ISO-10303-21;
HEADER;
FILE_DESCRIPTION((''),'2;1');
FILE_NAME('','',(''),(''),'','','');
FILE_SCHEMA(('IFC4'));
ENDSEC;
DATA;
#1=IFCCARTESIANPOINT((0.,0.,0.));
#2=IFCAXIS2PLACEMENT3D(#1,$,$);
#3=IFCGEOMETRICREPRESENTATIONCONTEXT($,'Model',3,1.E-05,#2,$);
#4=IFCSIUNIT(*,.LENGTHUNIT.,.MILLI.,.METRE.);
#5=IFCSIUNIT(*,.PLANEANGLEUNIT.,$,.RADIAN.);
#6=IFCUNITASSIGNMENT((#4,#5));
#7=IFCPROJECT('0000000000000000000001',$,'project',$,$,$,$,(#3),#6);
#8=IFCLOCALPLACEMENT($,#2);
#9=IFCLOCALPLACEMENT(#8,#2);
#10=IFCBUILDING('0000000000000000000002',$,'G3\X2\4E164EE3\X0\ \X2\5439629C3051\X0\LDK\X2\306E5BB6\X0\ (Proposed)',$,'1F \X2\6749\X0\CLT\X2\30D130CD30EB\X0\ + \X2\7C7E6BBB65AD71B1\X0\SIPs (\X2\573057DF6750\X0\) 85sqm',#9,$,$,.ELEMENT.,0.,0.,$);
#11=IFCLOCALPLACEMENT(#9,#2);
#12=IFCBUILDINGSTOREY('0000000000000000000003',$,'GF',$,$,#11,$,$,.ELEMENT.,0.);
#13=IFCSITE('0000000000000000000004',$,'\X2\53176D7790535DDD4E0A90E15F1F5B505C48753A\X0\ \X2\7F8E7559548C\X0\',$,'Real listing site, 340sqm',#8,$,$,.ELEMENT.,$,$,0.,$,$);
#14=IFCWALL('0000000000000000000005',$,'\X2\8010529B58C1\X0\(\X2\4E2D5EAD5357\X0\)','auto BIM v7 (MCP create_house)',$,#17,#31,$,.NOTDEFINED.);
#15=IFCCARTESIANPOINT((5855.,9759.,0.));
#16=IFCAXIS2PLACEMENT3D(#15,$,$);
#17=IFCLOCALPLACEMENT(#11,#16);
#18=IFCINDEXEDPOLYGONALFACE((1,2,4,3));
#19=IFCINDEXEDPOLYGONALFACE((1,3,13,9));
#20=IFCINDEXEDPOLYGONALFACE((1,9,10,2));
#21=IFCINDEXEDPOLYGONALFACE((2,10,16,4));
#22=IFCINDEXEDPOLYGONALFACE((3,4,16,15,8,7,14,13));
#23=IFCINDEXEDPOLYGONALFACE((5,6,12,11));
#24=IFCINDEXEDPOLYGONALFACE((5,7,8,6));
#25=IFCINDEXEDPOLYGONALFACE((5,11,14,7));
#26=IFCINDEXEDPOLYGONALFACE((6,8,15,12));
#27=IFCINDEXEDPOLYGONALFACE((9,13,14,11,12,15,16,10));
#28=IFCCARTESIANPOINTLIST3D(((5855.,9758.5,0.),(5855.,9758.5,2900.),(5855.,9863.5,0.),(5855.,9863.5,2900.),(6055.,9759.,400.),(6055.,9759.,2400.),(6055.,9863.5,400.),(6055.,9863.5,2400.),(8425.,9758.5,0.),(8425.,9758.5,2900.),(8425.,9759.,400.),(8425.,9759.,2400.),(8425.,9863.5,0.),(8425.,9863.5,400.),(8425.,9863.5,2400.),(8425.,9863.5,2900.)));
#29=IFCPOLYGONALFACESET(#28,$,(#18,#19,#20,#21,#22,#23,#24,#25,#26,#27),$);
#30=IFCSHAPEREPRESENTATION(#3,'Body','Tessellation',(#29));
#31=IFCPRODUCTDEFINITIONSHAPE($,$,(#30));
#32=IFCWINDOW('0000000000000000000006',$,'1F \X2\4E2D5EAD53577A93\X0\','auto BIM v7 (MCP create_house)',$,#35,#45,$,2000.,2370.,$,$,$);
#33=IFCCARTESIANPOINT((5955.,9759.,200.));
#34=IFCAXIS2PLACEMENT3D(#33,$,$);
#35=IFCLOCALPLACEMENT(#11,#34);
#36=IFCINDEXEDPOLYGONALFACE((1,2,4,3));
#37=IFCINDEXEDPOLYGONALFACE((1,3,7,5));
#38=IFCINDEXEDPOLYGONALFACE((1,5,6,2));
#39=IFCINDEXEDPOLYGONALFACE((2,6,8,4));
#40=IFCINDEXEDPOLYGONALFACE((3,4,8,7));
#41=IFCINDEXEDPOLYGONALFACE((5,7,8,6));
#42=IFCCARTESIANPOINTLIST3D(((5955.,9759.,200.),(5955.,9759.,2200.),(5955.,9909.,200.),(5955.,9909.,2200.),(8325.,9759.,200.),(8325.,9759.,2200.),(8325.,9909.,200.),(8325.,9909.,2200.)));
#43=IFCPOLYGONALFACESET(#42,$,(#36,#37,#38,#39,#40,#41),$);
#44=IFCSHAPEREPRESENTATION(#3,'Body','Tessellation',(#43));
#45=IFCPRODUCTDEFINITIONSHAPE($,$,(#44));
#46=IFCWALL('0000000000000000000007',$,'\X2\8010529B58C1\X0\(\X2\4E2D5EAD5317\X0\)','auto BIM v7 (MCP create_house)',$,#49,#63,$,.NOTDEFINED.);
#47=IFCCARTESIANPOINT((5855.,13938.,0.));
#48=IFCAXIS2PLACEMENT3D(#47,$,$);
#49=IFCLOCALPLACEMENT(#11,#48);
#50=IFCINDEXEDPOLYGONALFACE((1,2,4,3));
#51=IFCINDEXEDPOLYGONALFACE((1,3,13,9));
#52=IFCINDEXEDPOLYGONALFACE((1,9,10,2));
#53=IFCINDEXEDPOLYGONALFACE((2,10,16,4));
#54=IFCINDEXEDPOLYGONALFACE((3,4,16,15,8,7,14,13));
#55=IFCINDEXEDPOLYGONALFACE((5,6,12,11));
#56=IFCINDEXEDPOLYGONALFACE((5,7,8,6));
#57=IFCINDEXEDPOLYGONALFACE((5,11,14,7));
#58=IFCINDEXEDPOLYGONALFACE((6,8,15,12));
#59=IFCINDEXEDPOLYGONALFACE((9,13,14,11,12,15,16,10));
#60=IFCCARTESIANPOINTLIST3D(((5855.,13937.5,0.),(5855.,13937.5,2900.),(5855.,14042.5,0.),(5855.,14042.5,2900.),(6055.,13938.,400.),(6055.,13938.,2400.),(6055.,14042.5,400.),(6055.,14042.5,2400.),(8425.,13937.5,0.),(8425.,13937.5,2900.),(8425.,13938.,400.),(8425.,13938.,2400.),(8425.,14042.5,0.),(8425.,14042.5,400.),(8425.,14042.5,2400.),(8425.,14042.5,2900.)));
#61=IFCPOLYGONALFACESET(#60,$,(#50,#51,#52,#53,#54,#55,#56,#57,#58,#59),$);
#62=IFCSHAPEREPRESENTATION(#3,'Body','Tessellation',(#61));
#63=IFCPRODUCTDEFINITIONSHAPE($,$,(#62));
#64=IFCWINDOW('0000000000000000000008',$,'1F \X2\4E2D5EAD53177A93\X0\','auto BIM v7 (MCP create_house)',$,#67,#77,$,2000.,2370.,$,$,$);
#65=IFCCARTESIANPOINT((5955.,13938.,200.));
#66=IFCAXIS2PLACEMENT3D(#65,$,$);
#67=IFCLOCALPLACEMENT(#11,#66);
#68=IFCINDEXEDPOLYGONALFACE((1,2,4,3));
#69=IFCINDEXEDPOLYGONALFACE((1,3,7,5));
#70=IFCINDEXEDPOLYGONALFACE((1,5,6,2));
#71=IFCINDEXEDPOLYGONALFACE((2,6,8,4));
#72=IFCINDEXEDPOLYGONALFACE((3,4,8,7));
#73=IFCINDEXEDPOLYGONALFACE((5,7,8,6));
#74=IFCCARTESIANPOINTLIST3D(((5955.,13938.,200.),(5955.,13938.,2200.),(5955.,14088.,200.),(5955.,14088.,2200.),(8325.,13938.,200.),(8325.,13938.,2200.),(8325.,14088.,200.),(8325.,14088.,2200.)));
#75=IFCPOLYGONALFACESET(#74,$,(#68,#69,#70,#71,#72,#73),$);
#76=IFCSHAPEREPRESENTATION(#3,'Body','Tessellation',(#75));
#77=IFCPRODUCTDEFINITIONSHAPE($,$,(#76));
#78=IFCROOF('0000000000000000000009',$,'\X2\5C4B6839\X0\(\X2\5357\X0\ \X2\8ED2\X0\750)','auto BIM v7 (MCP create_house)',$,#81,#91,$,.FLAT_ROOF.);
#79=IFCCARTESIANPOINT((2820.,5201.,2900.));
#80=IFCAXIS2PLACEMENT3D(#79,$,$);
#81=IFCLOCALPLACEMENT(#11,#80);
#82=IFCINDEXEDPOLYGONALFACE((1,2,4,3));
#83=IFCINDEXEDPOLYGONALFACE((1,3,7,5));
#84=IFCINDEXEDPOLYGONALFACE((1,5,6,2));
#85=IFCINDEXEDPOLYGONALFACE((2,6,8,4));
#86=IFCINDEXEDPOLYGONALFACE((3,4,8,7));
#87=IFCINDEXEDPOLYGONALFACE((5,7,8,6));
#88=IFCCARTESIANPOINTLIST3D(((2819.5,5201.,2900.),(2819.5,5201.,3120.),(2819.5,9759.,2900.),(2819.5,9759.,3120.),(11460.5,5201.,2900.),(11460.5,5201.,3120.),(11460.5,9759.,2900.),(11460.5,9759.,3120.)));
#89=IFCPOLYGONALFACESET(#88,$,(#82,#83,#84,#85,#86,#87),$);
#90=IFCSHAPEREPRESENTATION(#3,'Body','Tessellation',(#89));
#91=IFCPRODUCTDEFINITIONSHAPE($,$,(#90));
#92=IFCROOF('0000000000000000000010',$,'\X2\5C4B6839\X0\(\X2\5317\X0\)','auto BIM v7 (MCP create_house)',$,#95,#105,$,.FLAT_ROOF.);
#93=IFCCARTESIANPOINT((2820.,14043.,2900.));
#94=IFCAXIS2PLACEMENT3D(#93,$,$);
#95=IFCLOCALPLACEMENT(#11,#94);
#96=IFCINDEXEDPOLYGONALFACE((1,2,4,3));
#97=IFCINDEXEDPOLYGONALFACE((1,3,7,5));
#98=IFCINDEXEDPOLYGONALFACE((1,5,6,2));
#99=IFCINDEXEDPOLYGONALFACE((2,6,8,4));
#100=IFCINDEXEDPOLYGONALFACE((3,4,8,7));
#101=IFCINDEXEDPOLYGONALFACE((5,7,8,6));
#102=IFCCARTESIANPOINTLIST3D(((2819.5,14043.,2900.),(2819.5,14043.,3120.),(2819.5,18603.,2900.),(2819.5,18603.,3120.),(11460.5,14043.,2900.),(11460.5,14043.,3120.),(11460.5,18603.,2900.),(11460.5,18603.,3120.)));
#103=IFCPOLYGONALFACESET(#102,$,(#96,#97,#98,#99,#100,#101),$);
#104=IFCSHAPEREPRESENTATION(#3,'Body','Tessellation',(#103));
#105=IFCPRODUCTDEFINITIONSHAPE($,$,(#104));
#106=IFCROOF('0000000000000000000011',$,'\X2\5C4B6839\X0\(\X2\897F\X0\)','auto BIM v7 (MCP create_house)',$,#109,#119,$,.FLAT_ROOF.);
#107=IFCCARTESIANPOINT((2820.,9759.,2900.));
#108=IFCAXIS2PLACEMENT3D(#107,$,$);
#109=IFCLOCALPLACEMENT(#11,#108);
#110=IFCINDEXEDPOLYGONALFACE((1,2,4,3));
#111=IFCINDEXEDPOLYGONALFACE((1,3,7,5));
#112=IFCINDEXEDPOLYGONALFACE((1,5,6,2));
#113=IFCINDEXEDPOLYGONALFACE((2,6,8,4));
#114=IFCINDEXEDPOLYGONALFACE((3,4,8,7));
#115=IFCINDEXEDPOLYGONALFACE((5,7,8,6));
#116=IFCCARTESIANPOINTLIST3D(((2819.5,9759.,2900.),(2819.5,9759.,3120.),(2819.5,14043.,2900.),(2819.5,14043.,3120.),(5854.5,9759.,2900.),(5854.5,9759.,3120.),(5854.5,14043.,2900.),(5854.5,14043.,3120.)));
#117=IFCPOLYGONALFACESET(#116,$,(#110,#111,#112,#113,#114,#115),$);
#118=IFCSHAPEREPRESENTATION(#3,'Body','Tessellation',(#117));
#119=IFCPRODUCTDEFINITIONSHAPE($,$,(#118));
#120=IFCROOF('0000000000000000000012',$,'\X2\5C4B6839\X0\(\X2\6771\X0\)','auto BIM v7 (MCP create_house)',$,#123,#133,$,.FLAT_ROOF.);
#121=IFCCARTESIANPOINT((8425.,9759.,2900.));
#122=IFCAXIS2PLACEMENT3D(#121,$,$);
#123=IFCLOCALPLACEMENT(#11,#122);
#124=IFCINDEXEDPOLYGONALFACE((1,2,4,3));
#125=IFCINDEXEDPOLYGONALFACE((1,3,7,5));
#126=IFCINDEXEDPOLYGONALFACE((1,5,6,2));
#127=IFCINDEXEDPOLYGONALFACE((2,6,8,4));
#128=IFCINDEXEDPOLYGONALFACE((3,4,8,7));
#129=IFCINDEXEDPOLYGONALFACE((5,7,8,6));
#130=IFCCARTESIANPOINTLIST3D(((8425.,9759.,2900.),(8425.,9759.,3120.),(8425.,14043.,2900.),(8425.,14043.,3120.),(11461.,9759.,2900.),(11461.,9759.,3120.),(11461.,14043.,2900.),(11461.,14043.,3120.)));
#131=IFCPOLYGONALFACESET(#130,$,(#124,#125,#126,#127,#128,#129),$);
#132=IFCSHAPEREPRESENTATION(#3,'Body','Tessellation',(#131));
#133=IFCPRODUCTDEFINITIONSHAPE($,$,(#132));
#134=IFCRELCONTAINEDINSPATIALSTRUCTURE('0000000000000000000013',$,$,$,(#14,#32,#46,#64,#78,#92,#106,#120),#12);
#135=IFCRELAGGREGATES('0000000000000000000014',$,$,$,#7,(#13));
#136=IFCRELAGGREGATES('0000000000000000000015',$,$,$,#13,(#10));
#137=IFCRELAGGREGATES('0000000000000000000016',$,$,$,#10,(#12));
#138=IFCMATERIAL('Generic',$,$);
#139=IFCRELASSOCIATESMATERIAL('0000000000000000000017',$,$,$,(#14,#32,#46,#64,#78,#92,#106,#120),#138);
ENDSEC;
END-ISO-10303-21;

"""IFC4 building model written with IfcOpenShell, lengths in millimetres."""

from ifc_helpers import new_model, si_unit, frame, frame_2d, origin, place, context, project, spatial, rectangle, extrude, material, element, fill, save


model = new_model("IFC4")

# Units and contexts
model_context = context("Model", 3, precision=1e-05, world=origin())
ifc_project = project(units=[si_unit("LENGTHUNIT", "METRE", prefix="MILLI"), si_unit("PLANEANGLEUNIT", "RADIAN")], contexts=[model_context])

# Site, building, storey
site_placement = place(None, origin())
site = spatial("IfcSite", under=ifc_project, at=site_placement, Name="北海道川上郡弟子屈町 美留和", ObjectType="Real listing site, 340sqm", CompositionType="ELEMENT", RefElevation=0.0)
building_placement = place(site_placement, origin())
building = spatial("IfcBuilding", under=site, at=building_placement, Name="G3世代 吹抜けLDKの家 (Proposed)", ObjectType="1F 杉CLTパネル + 籾殻断熱SIPs (地域材) 85sqm", CompositionType="ELEMENT", ElevationOfRefHeight=0.0, ElevationOfTerrain=0.0)
storey_placement = place(building_placement, origin())
storey = spatial("IfcBuildingStorey", under=building, at=storey_placement, Name="GF", CompositionType="ELEMENT", Elevation=0.0)

# Shared definitions
ifc_material = material(Name="Generic")

# Walls, openings, windows
wall_1_placement = place(storey_placement, frame((5855.0, 9759.0, 0.0)))
wall_1 = element("IfcWall", 1, at=wall_1_placement, inside=storey, material=ifc_material, Name="耐力壁(中庭南)", Description="auto BIM v7 (MCP create_house)", PredefinedType="NOTDEFINED", context=model_context, shape_type="SweptSolid", body=[
    extrude(rectangle(XDim=2570.0, YDim=105.0, at=frame_2d((1285.0, 52.0))), frame((5855.0, 9759.0, 0.0)), (0.0, 0.0, 1.0), 2900.0),
])
opening_1_placement = place(storey_placement, frame((5955.0, 9759.0, 200.0)))
opening_1 = element("IfcOpeningElement", 2, at=opening_1_placement, cuts=wall_1, PredefinedType="NOTDEFINED", context=model_context, shape_type="SweptSolid", body=[
    extrude(rectangle(XDim=2370.0, YDim=150.0, at=frame_2d((1185.0, 75.0))), frame((5955.0, 9759.0, 200.0)), (0.0, 0.0, 1.0), 2000.0),
])
window_1_placement = place(storey_placement, frame((5955.0, 9759.0, 200.0)))
window_1 = element("IfcWindow", 3, at=window_1_placement, inside=storey, material=ifc_material, Name="1F 中庭南窓", Description="auto BIM v7 (MCP create_house)", OverallHeight=2000.0, OverallWidth=2370.0, context=model_context, shape_type="SweptSolid", body=[
    extrude(rectangle(XDim=2370.0, YDim=150.0, at=frame_2d((1185.0, 75.0))), frame((5955.0, 9759.0, 200.0)), (0.0, 0.0, 1.0), 2000.0),
])
fill(opening_1, window_1)
wall_2_placement = place(storey_placement, frame((5855.0, 13938.0, 0.0)))
wall_2 = element("IfcWall", 4, at=wall_2_placement, inside=storey, material=ifc_material, Name="耐力壁(中庭北)", Description="auto BIM v7 (MCP create_house)", PredefinedType="NOTDEFINED", context=model_context, shape_type="SweptSolid", body=[
    extrude(rectangle(XDim=2570.0, YDim=105.0, at=frame_2d((1285.0, 52.0))), frame((5855.0, 13938.0, 0.0)), (0.0, 0.0, 1.0), 2900.0),
])
opening_2_placement = place(storey_placement, frame((5955.0, 13938.0, 200.0)))
opening_2 = element("IfcOpeningElement", 5, at=opening_2_placement, cuts=wall_2, PredefinedType="NOTDEFINED", context=model_context, shape_type="SweptSolid", body=[
    extrude(rectangle(XDim=2370.0, YDim=150.0, at=frame_2d((1185.0, 75.0))), frame((5955.0, 13938.0, 200.0)), (0.0, 0.0, 1.0), 2000.0),
])
window_2_placement = place(storey_placement, frame((5955.0, 13938.0, 200.0)))
window_2 = element("IfcWindow", 6, at=window_2_placement, inside=storey, material=ifc_material, Name="1F 中庭北窓", Description="auto BIM v7 (MCP create_house)", OverallHeight=2000.0, OverallWidth=2370.0, context=model_context, shape_type="SweptSolid", body=[
    extrude(rectangle(XDim=2370.0, YDim=150.0, at=frame_2d((1185.0, 75.0))), frame((5955.0, 13938.0, 200.0)), (0.0, 0.0, 1.0), 2000.0),
])
fill(opening_2, window_2)

# Roofs
roof_1_placement = place(storey_placement, frame((2820.0, 5201.0, 2900.0)))
element("IfcRoof", 7, at=roof_1_placement, inside=storey, material=ifc_material, Name="屋根(南 軒750)", Description="auto BIM v7 (MCP create_house)", PredefinedType="FLAT_ROOF", context=model_context, shape_type="SweptSolid", body=[
    extrude(rectangle(XDim=8641.0, YDim=4558.0, at=frame_2d((4320.0, 2279.0))), frame((2820.0, 5201.0, 2900.0)), (0.0, 0.0, 1.0), 220.0),
])
roof_2_placement = place(storey_placement, frame((2820.0, 14043.0, 2900.0)))
element("IfcRoof", 8, at=roof_2_placement, inside=storey, material=ifc_material, Name="屋根(北)", Description="auto BIM v7 (MCP create_house)", PredefinedType="FLAT_ROOF", context=model_context, shape_type="SweptSolid", body=[
    extrude(rectangle(XDim=8641.0, YDim=4560.0, at=frame_2d((4320.0, 2280.0))), frame((2820.0, 14043.0, 2900.0)), (0.0, 0.0, 1.0), 220.0),
])
roof_3_placement = place(storey_placement, frame((2820.0, 9759.0, 2900.0)))
element("IfcRoof", 9, at=roof_3_placement, inside=storey, material=ifc_material, Name="屋根(西)", Description="auto BIM v7 (MCP create_house)", PredefinedType="FLAT_ROOF", context=model_context, shape_type="SweptSolid", body=[
    extrude(rectangle(XDim=3035.0, YDim=4284.0, at=frame_2d((1517.0, 2142.0))), frame((2820.0, 9759.0, 2900.0)), (0.0, 0.0, 1.0), 220.0),
])
roof_4_placement = place(storey_placement, frame((8425.0, 9759.0, 2900.0)))
element("IfcRoof", 10, at=roof_4_placement, inside=storey, material=ifc_material, Name="屋根(東)", Description="auto BIM v7 (MCP create_house)", PredefinedType="FLAT_ROOF", context=model_context, shape_type="SweptSolid", body=[
    extrude(rectangle(XDim=3036.0, YDim=4284.0, at=frame_2d((1518.0, 2142.0))), frame((8425.0, 9759.0, 2900.0)), (0.0, 0.0, 1.0), 220.0),
])

save(model, "model.ifc")
